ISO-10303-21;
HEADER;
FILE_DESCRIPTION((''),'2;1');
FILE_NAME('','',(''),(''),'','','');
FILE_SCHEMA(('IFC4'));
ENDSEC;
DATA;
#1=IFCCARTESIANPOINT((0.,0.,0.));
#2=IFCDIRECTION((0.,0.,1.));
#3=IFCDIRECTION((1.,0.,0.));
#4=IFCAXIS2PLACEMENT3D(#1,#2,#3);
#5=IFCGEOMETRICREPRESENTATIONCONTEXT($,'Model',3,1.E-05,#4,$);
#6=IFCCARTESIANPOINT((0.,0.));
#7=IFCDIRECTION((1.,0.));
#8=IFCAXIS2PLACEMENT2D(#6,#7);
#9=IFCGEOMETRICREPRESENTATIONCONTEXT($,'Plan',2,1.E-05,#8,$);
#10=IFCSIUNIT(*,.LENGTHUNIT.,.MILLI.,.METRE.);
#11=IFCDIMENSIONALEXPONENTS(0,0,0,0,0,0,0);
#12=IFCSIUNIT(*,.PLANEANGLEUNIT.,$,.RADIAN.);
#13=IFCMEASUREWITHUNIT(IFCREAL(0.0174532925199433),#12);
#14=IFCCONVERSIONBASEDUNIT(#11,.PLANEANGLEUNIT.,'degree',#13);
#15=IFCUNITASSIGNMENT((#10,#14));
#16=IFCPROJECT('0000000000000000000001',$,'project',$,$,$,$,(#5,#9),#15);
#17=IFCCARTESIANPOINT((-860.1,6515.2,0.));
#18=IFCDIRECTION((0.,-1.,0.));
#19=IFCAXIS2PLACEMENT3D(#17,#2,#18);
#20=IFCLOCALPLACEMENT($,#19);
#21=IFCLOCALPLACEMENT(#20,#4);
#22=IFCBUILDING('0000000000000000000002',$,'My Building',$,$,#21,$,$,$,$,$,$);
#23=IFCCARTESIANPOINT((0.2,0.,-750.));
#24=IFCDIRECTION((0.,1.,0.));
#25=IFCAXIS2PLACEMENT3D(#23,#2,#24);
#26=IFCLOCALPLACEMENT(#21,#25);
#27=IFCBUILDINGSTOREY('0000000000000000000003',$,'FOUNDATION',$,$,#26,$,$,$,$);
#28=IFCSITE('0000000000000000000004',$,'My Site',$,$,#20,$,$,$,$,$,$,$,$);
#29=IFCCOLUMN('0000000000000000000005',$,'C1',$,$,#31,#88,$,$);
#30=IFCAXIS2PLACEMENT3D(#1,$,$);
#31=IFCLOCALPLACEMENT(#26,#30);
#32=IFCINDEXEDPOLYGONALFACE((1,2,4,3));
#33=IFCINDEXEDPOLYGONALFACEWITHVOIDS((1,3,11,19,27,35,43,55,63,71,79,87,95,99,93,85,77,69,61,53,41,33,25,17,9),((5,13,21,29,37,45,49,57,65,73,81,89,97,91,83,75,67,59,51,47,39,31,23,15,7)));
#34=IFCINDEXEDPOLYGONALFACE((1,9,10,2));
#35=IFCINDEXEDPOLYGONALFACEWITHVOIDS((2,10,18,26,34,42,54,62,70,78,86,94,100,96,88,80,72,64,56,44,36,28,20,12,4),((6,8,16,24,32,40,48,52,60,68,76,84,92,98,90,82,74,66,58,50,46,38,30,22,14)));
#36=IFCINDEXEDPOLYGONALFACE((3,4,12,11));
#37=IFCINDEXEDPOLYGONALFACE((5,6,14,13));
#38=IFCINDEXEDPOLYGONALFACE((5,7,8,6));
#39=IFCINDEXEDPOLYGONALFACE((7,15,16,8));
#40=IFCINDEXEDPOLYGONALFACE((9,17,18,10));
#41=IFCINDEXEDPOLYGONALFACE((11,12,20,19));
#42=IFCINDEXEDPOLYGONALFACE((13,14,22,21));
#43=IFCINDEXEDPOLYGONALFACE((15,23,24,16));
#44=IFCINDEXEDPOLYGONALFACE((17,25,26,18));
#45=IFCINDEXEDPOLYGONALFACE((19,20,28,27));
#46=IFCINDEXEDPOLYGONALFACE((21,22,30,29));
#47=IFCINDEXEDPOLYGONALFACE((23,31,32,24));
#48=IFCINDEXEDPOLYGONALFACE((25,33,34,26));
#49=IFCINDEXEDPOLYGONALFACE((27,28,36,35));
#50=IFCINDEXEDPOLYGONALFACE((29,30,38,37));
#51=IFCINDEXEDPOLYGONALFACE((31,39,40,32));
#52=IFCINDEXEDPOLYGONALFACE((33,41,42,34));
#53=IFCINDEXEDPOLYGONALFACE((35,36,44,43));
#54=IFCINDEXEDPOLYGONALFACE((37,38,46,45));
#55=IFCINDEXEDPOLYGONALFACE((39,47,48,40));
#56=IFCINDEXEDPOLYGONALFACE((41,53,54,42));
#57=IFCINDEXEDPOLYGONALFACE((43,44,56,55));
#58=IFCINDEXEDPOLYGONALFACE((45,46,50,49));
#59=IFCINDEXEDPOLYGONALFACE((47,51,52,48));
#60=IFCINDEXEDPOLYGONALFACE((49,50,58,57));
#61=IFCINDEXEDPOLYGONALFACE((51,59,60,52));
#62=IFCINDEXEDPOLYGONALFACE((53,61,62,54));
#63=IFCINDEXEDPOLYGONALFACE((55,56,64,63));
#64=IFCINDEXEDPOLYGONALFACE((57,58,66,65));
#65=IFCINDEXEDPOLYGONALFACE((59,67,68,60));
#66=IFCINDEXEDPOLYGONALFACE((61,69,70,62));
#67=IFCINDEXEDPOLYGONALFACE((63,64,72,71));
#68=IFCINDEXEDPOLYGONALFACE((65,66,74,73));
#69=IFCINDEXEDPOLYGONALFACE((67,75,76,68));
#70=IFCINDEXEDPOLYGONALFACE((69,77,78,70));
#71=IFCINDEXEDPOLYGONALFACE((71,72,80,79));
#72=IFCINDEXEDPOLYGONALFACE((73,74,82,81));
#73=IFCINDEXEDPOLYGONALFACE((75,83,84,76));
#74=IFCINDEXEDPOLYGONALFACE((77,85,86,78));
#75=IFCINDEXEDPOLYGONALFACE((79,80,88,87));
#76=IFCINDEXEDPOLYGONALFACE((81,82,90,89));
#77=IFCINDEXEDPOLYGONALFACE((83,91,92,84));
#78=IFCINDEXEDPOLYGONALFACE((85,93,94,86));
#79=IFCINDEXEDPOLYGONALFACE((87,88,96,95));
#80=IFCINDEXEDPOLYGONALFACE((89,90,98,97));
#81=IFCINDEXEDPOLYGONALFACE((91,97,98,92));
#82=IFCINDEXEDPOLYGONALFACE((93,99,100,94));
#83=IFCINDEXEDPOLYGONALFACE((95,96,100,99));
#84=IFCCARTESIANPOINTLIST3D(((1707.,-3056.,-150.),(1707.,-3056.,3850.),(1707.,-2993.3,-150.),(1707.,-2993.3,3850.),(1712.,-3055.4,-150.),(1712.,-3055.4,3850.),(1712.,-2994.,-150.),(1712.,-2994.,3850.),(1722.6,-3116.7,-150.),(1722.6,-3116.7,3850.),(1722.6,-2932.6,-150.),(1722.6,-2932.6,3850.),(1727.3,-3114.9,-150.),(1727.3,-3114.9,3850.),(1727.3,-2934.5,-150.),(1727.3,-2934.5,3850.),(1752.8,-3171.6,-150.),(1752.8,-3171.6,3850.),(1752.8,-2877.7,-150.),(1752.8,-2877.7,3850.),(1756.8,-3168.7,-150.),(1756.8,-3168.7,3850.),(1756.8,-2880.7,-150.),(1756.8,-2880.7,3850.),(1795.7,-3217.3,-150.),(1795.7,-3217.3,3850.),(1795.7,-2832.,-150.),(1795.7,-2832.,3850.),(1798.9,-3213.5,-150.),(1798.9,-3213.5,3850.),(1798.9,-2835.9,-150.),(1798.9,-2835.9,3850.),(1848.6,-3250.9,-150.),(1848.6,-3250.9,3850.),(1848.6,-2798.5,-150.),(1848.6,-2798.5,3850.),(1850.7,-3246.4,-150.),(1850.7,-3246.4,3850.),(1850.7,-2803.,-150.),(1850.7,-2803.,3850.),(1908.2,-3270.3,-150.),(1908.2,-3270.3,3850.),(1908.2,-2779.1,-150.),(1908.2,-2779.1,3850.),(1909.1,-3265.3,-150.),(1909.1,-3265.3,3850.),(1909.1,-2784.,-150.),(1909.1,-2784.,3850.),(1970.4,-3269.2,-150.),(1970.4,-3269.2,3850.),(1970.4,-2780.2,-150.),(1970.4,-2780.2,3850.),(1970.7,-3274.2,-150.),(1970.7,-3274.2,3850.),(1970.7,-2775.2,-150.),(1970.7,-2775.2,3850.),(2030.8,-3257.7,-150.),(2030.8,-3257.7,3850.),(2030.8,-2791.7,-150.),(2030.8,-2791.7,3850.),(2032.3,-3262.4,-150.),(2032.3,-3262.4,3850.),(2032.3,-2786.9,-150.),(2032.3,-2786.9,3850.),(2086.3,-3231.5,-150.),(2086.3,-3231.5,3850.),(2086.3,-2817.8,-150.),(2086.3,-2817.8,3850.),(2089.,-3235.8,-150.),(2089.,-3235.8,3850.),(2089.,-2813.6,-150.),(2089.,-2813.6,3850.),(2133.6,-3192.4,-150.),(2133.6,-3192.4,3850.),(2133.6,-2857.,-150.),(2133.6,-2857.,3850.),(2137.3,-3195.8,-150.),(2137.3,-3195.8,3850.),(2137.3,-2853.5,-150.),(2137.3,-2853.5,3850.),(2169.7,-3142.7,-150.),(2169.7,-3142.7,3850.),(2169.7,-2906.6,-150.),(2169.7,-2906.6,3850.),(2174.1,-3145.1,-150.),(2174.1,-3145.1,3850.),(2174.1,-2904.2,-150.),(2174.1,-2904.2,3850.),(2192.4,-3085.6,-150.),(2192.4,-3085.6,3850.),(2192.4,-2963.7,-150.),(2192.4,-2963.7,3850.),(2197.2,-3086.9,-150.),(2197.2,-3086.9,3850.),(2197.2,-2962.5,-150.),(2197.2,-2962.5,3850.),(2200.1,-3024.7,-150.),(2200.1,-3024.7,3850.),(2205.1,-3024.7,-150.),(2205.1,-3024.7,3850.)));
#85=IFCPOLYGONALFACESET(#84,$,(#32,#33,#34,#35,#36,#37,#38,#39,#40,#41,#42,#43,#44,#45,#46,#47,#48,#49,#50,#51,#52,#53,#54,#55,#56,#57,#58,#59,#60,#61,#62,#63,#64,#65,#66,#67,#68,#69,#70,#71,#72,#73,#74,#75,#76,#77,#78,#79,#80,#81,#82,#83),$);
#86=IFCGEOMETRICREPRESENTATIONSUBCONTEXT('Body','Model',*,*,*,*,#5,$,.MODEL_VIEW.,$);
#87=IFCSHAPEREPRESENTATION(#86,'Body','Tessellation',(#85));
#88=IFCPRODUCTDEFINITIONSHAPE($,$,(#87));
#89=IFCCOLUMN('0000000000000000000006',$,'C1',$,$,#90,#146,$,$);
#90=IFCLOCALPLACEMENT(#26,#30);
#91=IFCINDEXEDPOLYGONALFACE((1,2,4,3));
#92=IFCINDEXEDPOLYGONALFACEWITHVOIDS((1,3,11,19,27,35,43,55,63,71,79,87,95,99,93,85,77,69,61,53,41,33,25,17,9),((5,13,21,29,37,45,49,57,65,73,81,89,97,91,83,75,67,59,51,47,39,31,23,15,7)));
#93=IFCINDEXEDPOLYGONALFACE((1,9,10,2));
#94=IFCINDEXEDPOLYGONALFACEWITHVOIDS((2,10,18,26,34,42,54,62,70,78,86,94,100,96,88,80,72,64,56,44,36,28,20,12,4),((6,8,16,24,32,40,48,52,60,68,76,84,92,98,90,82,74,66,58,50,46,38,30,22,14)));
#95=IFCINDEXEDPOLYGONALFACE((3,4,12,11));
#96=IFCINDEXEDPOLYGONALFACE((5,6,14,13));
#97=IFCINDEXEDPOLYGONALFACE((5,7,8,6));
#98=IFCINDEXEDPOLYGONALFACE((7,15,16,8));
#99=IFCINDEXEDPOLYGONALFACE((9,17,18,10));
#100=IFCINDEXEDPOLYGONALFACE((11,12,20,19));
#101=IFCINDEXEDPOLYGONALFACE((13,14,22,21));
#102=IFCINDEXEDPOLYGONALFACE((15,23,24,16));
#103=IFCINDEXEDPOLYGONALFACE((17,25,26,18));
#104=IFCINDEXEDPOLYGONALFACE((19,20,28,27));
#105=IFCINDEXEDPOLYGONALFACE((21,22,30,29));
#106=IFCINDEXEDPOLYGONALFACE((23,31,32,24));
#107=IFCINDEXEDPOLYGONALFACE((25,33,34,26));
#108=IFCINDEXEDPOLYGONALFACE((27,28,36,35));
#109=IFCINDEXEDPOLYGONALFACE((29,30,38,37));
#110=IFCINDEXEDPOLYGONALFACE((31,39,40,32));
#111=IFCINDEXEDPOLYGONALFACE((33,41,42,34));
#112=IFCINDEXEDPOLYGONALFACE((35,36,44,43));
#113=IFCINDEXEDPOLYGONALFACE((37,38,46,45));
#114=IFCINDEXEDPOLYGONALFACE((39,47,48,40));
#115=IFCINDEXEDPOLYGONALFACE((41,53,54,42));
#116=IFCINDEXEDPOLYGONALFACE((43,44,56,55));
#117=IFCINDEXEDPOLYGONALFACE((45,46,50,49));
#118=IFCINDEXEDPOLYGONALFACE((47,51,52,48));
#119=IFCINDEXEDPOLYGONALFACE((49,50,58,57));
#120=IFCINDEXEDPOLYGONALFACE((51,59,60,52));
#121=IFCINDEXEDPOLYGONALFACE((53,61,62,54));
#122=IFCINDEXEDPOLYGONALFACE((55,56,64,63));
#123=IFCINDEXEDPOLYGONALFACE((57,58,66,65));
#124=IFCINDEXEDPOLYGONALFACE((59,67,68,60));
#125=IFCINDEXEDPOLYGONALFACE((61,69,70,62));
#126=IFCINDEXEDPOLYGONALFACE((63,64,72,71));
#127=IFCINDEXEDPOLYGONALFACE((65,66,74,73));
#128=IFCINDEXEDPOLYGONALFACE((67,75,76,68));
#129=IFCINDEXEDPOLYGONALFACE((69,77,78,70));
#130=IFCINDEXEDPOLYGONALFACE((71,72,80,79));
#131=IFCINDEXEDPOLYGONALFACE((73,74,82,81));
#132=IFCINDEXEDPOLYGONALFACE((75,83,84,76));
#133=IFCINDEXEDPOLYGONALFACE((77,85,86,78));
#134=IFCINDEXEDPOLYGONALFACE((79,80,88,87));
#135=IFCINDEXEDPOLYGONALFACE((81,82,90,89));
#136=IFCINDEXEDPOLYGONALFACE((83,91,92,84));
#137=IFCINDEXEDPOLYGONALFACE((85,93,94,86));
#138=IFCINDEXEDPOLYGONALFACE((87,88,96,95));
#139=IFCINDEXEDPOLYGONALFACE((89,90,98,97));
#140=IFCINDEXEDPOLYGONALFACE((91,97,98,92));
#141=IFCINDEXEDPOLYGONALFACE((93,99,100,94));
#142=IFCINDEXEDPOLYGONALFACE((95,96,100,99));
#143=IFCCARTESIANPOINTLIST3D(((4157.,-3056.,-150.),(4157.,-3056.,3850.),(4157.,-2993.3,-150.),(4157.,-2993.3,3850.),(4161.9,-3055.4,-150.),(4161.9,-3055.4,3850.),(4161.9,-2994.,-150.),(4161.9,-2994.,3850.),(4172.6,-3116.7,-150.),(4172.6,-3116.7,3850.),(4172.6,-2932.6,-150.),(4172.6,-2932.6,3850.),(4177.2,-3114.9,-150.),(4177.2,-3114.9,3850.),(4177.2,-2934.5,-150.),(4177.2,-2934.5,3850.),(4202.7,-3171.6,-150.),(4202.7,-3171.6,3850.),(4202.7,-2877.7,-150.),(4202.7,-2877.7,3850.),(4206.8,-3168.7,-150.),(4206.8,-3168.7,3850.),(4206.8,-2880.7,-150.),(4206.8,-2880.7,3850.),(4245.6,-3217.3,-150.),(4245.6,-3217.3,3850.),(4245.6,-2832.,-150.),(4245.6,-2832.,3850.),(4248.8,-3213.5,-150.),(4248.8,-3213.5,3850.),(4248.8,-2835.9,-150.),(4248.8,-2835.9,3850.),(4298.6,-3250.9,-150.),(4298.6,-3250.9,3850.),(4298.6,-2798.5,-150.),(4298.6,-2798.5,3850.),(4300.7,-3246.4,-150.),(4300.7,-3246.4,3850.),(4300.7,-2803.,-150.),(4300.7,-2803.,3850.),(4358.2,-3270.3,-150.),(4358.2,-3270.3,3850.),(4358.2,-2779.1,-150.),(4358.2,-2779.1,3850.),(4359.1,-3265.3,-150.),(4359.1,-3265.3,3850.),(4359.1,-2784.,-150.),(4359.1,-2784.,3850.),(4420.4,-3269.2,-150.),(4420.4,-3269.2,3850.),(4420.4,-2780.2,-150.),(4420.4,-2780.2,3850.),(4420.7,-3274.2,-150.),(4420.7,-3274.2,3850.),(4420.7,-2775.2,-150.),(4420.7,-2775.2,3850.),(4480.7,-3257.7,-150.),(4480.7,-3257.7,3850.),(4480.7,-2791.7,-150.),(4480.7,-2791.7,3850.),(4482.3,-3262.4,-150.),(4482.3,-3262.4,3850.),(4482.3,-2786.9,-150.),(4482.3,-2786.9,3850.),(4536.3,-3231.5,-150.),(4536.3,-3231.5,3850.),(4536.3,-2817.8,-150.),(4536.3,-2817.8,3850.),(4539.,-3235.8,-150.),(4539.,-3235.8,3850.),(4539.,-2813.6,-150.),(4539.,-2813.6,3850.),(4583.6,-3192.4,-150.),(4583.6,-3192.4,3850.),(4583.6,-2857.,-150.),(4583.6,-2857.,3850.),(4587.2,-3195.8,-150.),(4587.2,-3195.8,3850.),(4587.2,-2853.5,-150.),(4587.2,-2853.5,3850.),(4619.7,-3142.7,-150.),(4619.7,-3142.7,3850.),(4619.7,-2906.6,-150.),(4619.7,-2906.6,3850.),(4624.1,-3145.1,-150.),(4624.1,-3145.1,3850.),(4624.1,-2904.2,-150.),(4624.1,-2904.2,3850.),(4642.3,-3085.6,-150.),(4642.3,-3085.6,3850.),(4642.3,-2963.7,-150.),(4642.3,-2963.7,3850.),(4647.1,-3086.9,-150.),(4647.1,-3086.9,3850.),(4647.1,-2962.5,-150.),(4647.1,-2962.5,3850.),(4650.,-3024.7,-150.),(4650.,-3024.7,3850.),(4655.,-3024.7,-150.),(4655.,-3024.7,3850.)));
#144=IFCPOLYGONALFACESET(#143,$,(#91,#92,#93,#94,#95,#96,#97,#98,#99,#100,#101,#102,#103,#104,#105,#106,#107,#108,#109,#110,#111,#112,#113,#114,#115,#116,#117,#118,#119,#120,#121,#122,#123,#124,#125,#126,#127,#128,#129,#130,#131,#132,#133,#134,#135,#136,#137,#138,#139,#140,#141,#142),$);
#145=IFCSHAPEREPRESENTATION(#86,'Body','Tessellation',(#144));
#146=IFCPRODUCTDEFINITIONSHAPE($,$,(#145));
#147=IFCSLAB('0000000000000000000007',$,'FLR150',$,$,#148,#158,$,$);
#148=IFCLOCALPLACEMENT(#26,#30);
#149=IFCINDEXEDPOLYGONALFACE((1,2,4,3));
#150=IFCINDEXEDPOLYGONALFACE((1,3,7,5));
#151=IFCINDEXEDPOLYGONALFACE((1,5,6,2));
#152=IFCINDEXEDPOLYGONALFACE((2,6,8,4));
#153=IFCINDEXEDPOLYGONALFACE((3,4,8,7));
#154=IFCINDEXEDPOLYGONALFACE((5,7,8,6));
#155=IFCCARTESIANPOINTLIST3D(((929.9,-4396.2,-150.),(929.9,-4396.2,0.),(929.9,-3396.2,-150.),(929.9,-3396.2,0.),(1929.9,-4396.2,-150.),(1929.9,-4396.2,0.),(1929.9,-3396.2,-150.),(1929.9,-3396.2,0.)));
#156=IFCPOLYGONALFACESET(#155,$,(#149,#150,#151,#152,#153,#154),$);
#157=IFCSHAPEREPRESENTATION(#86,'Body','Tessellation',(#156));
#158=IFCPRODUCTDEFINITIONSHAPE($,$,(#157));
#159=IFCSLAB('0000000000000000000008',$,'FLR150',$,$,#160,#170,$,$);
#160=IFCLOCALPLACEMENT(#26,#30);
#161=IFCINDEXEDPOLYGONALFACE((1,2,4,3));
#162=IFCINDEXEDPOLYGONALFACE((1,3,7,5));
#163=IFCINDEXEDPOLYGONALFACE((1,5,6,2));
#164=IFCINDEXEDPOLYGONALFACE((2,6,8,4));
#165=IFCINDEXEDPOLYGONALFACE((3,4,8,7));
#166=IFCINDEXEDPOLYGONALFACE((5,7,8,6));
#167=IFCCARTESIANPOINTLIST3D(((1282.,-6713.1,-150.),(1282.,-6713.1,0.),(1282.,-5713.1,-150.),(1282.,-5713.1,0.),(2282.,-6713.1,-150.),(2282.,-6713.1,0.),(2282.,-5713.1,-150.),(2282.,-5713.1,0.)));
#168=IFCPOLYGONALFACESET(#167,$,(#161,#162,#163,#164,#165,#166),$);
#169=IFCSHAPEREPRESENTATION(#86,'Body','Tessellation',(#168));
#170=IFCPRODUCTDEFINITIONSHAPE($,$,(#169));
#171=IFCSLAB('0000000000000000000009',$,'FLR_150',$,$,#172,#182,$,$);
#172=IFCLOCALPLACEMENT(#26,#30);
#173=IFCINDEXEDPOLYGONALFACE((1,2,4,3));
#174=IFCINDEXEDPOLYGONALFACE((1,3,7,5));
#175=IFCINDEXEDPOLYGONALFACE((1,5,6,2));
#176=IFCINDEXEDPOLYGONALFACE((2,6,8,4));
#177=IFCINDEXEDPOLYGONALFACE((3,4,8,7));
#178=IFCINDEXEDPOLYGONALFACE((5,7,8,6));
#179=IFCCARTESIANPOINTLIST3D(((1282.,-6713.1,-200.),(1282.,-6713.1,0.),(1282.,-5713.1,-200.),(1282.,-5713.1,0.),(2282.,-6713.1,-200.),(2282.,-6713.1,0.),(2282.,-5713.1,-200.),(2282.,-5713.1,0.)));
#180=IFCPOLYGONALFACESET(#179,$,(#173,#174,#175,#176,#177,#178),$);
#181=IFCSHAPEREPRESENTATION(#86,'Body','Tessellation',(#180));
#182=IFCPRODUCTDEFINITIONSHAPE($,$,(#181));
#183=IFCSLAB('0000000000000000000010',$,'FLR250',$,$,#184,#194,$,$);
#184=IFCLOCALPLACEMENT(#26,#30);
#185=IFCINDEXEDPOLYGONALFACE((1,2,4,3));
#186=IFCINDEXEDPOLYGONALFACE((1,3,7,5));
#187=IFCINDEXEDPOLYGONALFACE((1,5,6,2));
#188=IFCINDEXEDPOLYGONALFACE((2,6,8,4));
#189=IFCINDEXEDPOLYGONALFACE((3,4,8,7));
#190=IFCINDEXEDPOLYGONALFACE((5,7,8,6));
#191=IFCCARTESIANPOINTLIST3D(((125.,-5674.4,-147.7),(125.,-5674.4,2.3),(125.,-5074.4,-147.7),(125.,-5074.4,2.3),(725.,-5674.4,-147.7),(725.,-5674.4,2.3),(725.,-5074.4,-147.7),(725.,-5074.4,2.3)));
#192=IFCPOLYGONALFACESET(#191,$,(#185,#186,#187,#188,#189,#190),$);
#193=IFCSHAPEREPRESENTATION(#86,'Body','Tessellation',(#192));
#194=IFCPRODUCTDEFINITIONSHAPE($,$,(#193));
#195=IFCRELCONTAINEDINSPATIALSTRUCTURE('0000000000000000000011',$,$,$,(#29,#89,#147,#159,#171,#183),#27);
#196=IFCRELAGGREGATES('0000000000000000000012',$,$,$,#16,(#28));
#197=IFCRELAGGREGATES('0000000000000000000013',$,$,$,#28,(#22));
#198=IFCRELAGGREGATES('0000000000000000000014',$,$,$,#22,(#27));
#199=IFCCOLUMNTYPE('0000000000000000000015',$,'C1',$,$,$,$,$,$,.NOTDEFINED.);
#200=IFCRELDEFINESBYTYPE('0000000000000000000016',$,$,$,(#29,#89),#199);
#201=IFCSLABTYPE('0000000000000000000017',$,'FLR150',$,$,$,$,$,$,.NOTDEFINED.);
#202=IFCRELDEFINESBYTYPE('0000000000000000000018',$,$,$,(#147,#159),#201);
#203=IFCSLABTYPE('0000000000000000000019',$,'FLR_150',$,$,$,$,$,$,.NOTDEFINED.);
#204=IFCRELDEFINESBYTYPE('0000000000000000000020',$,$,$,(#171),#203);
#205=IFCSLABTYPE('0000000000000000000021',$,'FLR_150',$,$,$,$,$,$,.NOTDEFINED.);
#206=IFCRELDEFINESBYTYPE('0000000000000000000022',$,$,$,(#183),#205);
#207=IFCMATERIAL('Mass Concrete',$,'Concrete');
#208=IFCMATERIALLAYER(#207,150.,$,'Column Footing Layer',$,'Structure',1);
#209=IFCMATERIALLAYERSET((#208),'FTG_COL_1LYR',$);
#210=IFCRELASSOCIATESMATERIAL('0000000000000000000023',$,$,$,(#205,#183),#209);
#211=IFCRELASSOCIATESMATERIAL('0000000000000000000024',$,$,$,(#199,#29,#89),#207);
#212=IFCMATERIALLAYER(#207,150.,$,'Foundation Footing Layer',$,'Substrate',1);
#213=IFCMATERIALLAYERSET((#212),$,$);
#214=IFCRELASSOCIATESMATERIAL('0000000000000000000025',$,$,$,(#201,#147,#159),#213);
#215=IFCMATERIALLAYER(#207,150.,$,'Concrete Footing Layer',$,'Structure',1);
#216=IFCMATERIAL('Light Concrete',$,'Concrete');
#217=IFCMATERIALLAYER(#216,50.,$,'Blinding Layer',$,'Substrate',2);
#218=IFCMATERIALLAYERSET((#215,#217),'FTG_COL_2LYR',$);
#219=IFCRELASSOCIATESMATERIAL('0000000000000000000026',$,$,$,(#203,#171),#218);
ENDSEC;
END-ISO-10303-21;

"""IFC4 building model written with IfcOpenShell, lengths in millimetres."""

from ifc_helpers import new_model, entity, si_unit, converted_unit, frame, origin_with_axes, origin_2d_with_axis, place, context, subcontext, project, spatial, line, indexed_curve, rectangle, hollow_circle, outline, extrude, material, layer, layer_set, layer_usage, material_profile, profile_set, profile_usage, type_object, element, save


model = new_model("IFC4")

# Units and contexts
model_context = context("Model", 3, precision=1e-05, world=origin_with_axes())
plan_context = context("Plan", 2, precision=1e-05, world=origin_2d_with_axis())
body_context = subcontext(model_context, "Body", "Model", "MODEL_VIEW")
ifc_project = project(units=[si_unit("LENGTHUNIT", "METRE", prefix="MILLI"), converted_unit("PLANEANGLEUNIT", "degree", entity("IfcReal", 0.0174532925199433), si_unit("PLANEANGLEUNIT", "RADIAN"), dimensions=[0, 0, 0, 0, 0, 0, 0])], contexts=[model_context, plan_context])

# Site, building, storey
site_placement = place(None, frame((-860.1, 6515.2, 0.0), z_axis=(0.0, 0.0, 1.0), x_axis=(0.0, -1.0, 0.0)))
site = spatial("IfcSite", under=ifc_project, at=site_placement, Name="My Site")
building_placement = place(site_placement, frame((0.0, 0.0, 0.0), z_axis=(0.0, 0.0, 1.0), x_axis=(1.0, 0.0, 0.0)))
building = spatial("IfcBuilding", under=site, at=building_placement, Name="My Building")
storey_placement = place(building_placement, frame((0.2, 0.0, -750.0), z_axis=(0.0, 0.0, 1.0), x_axis=(0.0, 1.0, 0.0)))
storey = spatial("IfcBuildingStorey", under=building, at=storey_placement, Name="FOUNDATION")

# Shared definitions
ifc_material_1 = material(Name="Mass Concrete", Category="Concrete")
ifc_layer_1 = layer(ifc_material_1, 150.0, Name="Column Footing Layer", Category="Structure", Priority=1)
ifc_layer_set_1 = layer_set([ifc_layer_1], Name="FTG_COL_1LYR")
slab_type_1 = type_object("IfcSlabType", Name="FLR_150", PredefinedType="NOTDEFINED", material=ifc_layer_set_1)

# Columns
ifc_material_profile = material_profile(ifc_material_1, rectangle(XDim=150.0, YDim=150.0), Name="Square Column", Category="Structure", Priority=1)
ifc_profile_set = profile_set([ifc_material_profile], Name="RC_COL_150x150")
column_type = type_object("IfcColumnType", Name="C1", PredefinedType="NOTDEFINED", material=ifc_profile_set)
ifc_profile_usage_1 = profile_usage(ifc_profile_set, cardinal=5)
column_1_placement = place(storey_placement, frame((1955.1, -3024.7, -150.0), z_axis=(0.0, 0.0, 1.0), x_axis=(1.0, 0.0, 0.0)))
element("IfcColumn", 1, at=column_1_placement, inside=storey, type_object=column_type, material=ifc_profile_usage_1, Name="C1", context=body_context, shape_type="SweptSolid", body=[
    extrude(hollow_circle(Radius=250.0, WallThickness=5.0), origin_with_axes(), (0.0, 0.0, 1.0), 4000.0),
])
ifc_profile_usage_2 = profile_usage(ifc_profile_set, cardinal=5)
column_2_placement = place(storey_placement, frame((4405.0, -3024.7, -150.0), z_axis=(0.0, 0.0, 1.0), x_axis=(1.0, 0.0, 0.0)))
element("IfcColumn", 2, at=column_2_placement, inside=storey, type_object=column_type, material=ifc_profile_usage_2, Name="C1", context=body_context, shape_type="SweptSolid", body=[
    extrude(hollow_circle(Radius=250.0, WallThickness=5.0), origin_with_axes(), (0.0, 0.0, 1.0), 4000.0),
])

# Slabs
ifc_layer_2 = layer(ifc_material_1, 150.0, Name="Foundation Footing Layer", Category="Substrate", Priority=1)
ifc_layer_set_2 = layer_set([ifc_layer_2])
ifc_layer_usage_1 = layer_usage(ifc_layer_set_2, "AXIS3", "POSITIVE", 0.0)
slab_type_2 = type_object("IfcSlabType", Name="FLR150", PredefinedType="NOTDEFINED", material=ifc_layer_set_2)
slab_1_placement = place(storey_placement, frame((929.9, -4396.2, -150.0), z_axis=(0.0, 0.0, 1.0), x_axis=(1.0, 0.0, 0.0)))
element("IfcSlab", 3, at=slab_1_placement, inside=storey, type_object=slab_type_2, material=ifc_layer_usage_1, Name="FLR150", context=body_context, shape_type="SweptSolid", body=[
    extrude(outline(indexed_curve([(0.0, 0.0), (1000.0, 0.0), (1000.0, 1000.0), (0.0, 1000.0), (0.0, 0.0)])), None, (0.0, 0.0, 1.0), 150.0),
])
ifc_layer_usage_2 = layer_usage(ifc_layer_set_2, "AXIS3", "POSITIVE", 0.0)
slab_2_placement = place(storey_placement, frame((1282.0, -6713.1, -150.0), z_axis=(0.0, 0.0, 1.0), x_axis=(1.0, 0.0, 0.0)))
element("IfcSlab", 4, at=slab_2_placement, inside=storey, type_object=slab_type_2, material=ifc_layer_usage_2, Name="FLR150", context=body_context, shape_type="SweptSolid", body=[
    extrude(outline(indexed_curve([(0.0, 0.0), (1000.0, 0.0), (1000.0, 1000.0), (0.0, 1000.0), (0.0, 0.0)])), None, (0.0, 0.0, 1.0), 150.0),
])
ifc_layer_3 = layer(ifc_material_1, 150.0, Name="Concrete Footing Layer", Category="Structure", Priority=1)
ifc_material_2 = material(Name="Light Concrete", Category="Concrete")
ifc_layer_4 = layer(ifc_material_2, 50.0, Name="Blinding Layer", Category="Substrate", Priority=2)
ifc_layer_set_3 = layer_set([ifc_layer_3, ifc_layer_4], Name="FTG_COL_2LYR")
ifc_layer_usage_3 = layer_usage(ifc_layer_set_3, "AXIS3", "POSITIVE", 0.0)
slab_type_3 = type_object("IfcSlabType", Name="FLR_150", PredefinedType="NOTDEFINED", material=ifc_layer_set_3)
slab_3_placement = place(storey_placement, frame((1282.0, -6713.1, -200.0), z_axis=(0.0, 0.0, 1.0), x_axis=(1.0, 0.0, 0.0)))
element("IfcSlab", 5, at=slab_3_placement, inside=storey, type_object=slab_type_3, material=ifc_layer_usage_3, Name="FLR_150", context=body_context, shape_type="SweptSolid", body=[
    extrude(outline(indexed_curve([(0.0, 0.0), (1000.0, 0.0), (1000.0, 1000.0), (0.0, 1000.0), (0.0, 0.0)])), None, (0.0, 0.0, 1.0), 200.0),
])
ifc_layer_usage_4 = layer_usage(ifc_layer_set_1, "AXIS3", "POSITIVE", 0.0)
slab_4_placement = place(storey_placement, frame((125.0, -5674.4, -147.7), z_axis=(0.0, 0.0, 1.0), x_axis=(1.0, 0.0, 0.0)))
element("IfcSlab", 6, at=slab_4_placement, inside=storey, type_object=slab_type_1, material=ifc_layer_usage_4, Name="FLR250", context=body_context, shape_type="SweptSolid", body=[
    extrude(outline(indexed_curve([(0.0, 0.0), (600.0, 0.0), (600.0, 600.0), (0.0, 600.0)], segments=[line(3, 2), line(2, 1), line(1, 4), line(4, 3)], self_intersect=False)), None, (0.0, 0.0, 1.0), 150.0),
])

save(model, "model.ifc")
